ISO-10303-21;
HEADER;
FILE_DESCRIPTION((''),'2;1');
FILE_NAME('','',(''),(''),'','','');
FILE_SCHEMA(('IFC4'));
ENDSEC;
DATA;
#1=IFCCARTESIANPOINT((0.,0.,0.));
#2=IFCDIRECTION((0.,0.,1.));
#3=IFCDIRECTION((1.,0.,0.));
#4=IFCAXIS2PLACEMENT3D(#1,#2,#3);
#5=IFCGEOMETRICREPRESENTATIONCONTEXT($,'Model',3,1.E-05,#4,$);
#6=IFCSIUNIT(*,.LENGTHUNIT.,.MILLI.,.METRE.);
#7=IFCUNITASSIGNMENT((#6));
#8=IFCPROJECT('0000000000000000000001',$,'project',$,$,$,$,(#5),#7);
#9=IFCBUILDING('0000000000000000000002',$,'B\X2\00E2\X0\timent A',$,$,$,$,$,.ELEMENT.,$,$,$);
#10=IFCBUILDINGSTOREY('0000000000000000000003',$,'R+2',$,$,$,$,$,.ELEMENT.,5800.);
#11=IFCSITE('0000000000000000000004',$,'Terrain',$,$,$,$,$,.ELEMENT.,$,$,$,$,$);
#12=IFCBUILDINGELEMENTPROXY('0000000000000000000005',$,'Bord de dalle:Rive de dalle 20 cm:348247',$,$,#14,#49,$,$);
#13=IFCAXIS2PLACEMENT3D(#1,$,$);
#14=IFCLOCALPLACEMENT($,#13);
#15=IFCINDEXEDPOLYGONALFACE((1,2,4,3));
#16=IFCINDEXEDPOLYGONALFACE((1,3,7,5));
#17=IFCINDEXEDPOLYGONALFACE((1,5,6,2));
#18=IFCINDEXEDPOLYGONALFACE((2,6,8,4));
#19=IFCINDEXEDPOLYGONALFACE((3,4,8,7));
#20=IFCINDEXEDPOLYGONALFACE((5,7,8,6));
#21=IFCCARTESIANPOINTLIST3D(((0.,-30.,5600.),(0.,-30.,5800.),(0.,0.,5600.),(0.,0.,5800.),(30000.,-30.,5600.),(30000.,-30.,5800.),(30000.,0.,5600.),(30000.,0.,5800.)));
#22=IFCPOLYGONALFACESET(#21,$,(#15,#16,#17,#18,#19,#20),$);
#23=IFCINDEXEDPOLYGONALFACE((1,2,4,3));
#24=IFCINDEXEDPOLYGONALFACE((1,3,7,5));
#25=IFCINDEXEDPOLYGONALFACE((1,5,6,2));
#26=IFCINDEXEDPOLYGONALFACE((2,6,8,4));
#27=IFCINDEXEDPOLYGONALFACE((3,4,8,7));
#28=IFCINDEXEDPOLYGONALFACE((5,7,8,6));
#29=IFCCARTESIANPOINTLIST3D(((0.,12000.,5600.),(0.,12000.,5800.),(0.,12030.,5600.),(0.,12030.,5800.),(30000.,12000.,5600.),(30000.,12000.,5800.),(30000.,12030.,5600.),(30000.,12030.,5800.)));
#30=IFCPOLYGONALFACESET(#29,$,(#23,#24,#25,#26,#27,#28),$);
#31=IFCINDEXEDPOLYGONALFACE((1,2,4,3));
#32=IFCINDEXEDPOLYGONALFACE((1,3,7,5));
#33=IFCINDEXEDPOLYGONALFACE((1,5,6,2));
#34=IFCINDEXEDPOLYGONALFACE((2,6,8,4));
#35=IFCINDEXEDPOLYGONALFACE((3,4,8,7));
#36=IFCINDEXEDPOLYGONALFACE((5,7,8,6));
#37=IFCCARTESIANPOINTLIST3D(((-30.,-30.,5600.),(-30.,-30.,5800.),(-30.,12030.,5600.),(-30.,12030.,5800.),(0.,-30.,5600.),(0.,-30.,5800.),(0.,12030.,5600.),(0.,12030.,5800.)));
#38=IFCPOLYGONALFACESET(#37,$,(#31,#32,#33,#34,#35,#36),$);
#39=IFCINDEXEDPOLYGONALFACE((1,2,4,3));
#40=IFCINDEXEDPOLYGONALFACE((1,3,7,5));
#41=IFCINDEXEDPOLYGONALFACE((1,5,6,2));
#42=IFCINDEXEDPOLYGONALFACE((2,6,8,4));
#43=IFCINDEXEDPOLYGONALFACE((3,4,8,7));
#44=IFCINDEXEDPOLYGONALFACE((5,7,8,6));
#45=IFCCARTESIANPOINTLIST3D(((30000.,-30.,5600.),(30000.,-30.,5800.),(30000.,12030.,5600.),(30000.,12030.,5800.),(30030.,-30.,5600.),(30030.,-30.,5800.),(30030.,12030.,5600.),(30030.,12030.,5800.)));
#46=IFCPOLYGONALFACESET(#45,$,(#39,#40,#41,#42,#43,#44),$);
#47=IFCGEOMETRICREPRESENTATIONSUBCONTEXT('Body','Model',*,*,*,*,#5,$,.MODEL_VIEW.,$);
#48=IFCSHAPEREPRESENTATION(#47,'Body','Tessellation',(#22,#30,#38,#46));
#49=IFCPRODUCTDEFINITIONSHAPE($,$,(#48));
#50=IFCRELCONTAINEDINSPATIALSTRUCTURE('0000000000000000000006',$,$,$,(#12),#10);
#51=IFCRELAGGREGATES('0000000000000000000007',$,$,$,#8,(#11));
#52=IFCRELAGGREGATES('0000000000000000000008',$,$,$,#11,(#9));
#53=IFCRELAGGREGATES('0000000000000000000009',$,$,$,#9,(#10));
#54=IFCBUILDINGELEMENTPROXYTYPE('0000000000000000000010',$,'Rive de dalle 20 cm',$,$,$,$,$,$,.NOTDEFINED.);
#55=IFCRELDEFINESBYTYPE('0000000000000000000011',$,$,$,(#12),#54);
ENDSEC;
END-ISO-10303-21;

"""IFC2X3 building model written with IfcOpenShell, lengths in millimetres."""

from ifc_helpers import new_model, si_unit, frame, frame_2d, origin_with_axes, place, context, subcontext, project, spatial, rectangle, extrude, type_object, element, save


model = new_model("IFC2X3")

# Units and contexts
model_context = context("Model", 3, precision=1e-05, world=origin_with_axes())
body_context = subcontext(model_context, "Body", "Model", "MODEL_VIEW")
ifc_project = project(units=[si_unit("LENGTHUNIT", "METRE", prefix="MILLI")], contexts=[model_context])

# Site, building, storey
site = spatial("IfcSite", under=ifc_project, Name="Terrain", CompositionType="ELEMENT")
building = spatial("IfcBuilding", under=site, Name="Bâtiment A", CompositionType="ELEMENT")
storey = spatial("IfcBuildingStorey", under=building, Name="R+2", CompositionType="ELEMENT", Elevation=5800.0)

# Building element proxy
building_element_proxy_type = type_object("IfcBuildingElementProxyType", Name="Rive de dalle 20 cm", PredefinedType="NOTDEFINED")
proxy_placement = place(None, origin_with_axes())
element("IfcBuildingElementProxy", 1, at=proxy_placement, inside=storey, type_object=building_element_proxy_type, Name="Bord de dalle:Rive de dalle 20 cm:348247", context=body_context, shape_type="SweptSolid", body=[
    extrude(rectangle(XDim=30000.0, YDim=30.0, at=frame_2d((15000.0, -15.0))), frame((0.0, 0.0, 5600.0), z_axis=(0.0, 0.0, 1.0), x_axis=(1.0, 0.0, 0.0)), (0.0, 0.0, 1.0), 200.0),
    extrude(rectangle(XDim=30000.0, YDim=30.0, at=frame_2d((15000.0, 12015.0))), frame((0.0, 0.0, 5600.0), z_axis=(0.0, 0.0, 1.0), x_axis=(1.0, 0.0, 0.0)), (0.0, 0.0, 1.0), 200.0),
    extrude(rectangle(XDim=30.0, YDim=12060.0, at=frame_2d((-15.0, 6000.0))), frame((0.0, 0.0, 5600.0), z_axis=(0.0, 0.0, 1.0), x_axis=(1.0, 0.0, 0.0)), (0.0, 0.0, 1.0), 200.0),
    extrude(rectangle(XDim=30.0, YDim=12060.0, at=frame_2d((30015.0, 6000.0))), frame((0.0, 0.0, 5600.0), z_axis=(0.0, 0.0, 1.0), x_axis=(1.0, 0.0, 0.0)), (0.0, 0.0, 1.0), 200.0),
])

save(model, "model.ifc")
